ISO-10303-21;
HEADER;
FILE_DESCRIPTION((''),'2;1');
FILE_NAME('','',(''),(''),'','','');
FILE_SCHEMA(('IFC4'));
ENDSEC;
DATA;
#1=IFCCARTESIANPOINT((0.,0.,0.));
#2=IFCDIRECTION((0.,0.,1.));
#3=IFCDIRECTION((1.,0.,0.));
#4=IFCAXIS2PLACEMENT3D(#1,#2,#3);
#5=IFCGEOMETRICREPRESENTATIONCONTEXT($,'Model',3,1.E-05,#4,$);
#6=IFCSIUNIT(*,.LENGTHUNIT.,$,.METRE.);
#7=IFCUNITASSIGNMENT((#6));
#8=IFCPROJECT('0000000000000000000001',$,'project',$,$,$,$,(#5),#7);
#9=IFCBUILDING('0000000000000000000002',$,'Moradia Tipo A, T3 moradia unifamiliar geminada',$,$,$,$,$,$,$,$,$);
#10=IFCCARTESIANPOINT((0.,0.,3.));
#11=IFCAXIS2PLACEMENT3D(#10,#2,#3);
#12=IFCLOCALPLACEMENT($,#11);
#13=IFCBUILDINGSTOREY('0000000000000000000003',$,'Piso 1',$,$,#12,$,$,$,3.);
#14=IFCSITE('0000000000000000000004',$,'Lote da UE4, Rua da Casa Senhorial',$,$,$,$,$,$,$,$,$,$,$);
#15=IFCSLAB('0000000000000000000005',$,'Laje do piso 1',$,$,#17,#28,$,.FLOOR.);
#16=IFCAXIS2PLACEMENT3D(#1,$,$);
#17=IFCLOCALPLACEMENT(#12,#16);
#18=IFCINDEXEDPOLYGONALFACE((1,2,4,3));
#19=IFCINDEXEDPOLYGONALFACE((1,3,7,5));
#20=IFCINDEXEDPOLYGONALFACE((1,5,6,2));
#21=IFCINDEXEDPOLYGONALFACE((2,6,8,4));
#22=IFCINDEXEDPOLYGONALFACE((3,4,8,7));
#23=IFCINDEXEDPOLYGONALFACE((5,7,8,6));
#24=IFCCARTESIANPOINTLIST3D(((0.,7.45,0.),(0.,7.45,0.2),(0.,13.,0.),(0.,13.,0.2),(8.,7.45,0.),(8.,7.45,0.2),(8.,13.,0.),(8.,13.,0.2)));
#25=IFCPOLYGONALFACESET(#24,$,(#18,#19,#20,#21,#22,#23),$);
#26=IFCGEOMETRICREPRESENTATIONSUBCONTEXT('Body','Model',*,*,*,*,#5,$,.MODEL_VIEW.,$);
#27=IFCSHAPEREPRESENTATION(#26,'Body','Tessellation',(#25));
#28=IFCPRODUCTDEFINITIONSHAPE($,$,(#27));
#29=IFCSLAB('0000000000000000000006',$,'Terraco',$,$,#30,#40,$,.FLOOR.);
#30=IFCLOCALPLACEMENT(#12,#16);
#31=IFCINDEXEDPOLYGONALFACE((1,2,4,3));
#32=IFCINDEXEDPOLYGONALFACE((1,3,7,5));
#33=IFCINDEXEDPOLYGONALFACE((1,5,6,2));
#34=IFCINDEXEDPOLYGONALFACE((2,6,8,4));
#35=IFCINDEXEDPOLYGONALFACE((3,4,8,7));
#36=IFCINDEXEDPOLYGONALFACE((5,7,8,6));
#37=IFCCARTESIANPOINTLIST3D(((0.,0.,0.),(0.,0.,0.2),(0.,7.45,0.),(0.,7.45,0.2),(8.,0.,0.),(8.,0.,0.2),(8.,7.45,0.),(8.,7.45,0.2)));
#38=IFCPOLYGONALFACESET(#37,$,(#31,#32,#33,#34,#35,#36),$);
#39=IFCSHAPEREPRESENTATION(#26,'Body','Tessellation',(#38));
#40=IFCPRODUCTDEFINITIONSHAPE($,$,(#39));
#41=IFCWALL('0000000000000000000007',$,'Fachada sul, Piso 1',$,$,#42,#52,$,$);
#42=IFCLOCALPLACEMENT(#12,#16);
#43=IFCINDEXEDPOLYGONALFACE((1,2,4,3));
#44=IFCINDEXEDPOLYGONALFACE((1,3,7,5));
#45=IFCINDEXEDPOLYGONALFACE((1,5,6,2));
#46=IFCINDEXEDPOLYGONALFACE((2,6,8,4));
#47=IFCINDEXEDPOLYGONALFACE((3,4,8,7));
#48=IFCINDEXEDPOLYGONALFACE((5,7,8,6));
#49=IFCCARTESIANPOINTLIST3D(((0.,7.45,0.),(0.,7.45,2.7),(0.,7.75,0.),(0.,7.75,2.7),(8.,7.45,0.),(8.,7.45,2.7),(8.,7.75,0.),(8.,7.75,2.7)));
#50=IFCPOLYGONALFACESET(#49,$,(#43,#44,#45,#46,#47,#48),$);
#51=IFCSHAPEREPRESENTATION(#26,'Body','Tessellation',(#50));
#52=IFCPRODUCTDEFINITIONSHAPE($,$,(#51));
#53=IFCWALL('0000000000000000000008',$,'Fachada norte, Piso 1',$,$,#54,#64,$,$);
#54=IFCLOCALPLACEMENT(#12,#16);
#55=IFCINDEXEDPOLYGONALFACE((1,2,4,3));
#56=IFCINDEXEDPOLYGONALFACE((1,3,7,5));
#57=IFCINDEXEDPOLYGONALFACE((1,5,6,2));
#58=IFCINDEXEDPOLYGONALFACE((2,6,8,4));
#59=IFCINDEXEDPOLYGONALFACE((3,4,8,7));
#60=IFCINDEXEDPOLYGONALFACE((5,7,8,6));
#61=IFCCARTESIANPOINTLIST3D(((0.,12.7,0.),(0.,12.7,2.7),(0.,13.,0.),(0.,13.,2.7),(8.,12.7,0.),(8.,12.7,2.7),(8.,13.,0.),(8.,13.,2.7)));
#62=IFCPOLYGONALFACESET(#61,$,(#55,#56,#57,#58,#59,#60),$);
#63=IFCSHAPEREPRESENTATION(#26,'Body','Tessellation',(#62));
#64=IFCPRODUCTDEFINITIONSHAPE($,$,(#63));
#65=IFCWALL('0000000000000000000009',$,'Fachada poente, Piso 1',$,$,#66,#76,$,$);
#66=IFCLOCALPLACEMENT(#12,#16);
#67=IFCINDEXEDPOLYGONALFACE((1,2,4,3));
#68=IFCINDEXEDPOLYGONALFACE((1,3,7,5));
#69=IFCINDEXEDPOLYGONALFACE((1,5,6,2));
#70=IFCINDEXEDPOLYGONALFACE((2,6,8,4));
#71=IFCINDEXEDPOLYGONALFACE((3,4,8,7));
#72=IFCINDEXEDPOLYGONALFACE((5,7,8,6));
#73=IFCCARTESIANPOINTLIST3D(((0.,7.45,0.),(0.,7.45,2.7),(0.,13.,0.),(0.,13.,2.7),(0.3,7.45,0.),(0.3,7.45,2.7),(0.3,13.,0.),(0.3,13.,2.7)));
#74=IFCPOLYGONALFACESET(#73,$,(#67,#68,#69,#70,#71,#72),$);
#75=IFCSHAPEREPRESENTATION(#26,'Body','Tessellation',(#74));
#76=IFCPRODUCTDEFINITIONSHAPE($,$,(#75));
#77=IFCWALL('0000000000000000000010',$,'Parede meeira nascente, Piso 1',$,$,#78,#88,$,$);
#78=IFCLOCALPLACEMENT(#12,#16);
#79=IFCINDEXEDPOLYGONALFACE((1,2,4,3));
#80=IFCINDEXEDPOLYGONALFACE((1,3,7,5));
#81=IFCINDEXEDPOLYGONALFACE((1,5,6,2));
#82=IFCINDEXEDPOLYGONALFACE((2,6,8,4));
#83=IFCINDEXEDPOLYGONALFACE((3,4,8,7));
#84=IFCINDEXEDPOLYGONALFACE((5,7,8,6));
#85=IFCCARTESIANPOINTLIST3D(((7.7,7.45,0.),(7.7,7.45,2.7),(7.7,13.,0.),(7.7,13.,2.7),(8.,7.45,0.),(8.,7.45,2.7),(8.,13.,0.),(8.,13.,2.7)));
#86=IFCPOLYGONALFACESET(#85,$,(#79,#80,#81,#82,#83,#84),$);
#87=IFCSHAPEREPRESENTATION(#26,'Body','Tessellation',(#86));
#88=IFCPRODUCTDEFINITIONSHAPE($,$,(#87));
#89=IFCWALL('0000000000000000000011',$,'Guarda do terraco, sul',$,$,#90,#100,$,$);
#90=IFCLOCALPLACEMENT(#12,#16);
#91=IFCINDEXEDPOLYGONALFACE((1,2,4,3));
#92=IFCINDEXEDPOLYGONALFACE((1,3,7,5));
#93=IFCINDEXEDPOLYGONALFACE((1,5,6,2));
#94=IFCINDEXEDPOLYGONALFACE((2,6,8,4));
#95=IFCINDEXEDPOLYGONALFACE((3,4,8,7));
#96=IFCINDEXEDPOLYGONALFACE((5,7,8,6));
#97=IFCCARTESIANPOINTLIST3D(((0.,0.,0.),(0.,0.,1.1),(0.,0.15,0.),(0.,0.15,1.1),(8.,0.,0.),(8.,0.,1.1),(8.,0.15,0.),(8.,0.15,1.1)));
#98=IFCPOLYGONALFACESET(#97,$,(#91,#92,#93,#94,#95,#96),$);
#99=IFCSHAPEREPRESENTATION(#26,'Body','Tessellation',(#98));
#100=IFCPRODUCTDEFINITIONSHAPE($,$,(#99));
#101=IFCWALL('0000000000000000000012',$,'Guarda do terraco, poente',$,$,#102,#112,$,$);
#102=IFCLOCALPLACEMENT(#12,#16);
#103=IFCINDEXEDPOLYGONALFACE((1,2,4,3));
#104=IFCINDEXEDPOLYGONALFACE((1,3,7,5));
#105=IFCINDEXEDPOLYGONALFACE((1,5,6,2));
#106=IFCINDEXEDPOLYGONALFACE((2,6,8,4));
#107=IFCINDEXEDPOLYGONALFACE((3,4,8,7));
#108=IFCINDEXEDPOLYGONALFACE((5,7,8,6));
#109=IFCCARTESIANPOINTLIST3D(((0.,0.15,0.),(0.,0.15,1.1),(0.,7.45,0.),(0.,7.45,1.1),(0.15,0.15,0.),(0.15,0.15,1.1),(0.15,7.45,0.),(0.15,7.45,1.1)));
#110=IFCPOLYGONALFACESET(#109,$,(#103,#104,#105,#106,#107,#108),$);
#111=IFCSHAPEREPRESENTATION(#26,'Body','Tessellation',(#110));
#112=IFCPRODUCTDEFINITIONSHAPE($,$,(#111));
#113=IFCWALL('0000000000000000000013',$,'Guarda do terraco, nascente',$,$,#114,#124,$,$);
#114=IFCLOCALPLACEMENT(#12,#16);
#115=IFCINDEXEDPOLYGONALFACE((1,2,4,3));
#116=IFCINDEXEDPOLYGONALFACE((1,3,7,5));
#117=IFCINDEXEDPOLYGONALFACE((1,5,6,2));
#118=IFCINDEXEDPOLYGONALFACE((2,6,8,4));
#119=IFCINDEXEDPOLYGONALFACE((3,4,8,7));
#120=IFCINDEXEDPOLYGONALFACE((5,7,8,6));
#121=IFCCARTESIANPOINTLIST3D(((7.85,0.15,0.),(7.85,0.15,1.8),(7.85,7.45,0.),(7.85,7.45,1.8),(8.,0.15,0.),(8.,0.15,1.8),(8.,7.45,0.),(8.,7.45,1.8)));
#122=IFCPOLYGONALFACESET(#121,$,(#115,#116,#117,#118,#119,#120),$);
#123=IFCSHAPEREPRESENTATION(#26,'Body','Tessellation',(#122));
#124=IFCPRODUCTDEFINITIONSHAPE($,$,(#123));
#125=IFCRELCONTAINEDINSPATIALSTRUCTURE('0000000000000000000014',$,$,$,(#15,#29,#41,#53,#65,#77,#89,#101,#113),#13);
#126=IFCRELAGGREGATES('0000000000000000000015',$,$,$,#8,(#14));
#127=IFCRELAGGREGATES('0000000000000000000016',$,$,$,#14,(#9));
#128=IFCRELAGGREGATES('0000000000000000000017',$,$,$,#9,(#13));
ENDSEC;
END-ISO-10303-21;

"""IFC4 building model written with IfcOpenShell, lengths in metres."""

from ifc_helpers import new_model, si_unit, frame, origin_with_axes, place, context, subcontext, project, spatial, indexed_curve, outline, extrude, element, save


model = new_model("IFC4")

# Units and contexts
model_context = context("Model", 3, precision=1e-05, world=origin_with_axes())
body_context = subcontext(model_context, "Body", "Model", "MODEL_VIEW")
ifc_project = project(units=[si_unit("LENGTHUNIT", "METRE")], contexts=[model_context])

# Site, building, storey
site = spatial("IfcSite", under=ifc_project, Name="Lote da UE4, Rua da Casa Senhorial")
building = spatial("IfcBuilding", under=site, Name="Moradia Tipo A, T3 moradia unifamiliar geminada")
storey_placement = place(None, frame((0.0, 0.0, 3.0), z_axis=(0.0, 0.0, 1.0), x_axis=(1.0, 0.0, 0.0)))
storey = spatial("IfcBuildingStorey", under=building, at=storey_placement, Name="Piso 1", Elevation=3.0)

# Slabs
slab_1_placement = place(storey_placement, frame((0.0, 7.45, 0.0), z_axis=(0.0, 0.0, 1.0), x_axis=(1.0, 0.0, 0.0)))
element("IfcSlab", 1, at=slab_1_placement, inside=storey, Name="Laje do piso 1", PredefinedType="FLOOR", context=body_context, shape_type="SweptSolid", body=[
    extrude(outline(indexed_curve([(0.0, 0.0), (8.0, 0.0), (8.0, 5.55), (0.0, 5.55), (0.0, 0.0)])), None, (0.0, 0.0, 1.0), 0.2),
])
slab_2_placement = place(storey_placement, origin_with_axes())
element("IfcSlab", 2, at=slab_2_placement, inside=storey, Name="Terraco", PredefinedType="FLOOR", context=body_context, shape_type="SweptSolid", body=[
    extrude(outline(indexed_curve([(0.0, 0.0), (8.0, 0.0), (8.0, 7.45), (0.0, 7.45), (0.0, 0.0)])), None, (0.0, 0.0, 1.0), 0.2),
])

# Walls
for number, where, z_axis, x_axis, name in (
    (3, (0.0, 7.45, 0.0), (0.0, 0.0, 1.0), (1.0, 0.0, 0.0), "Fachada sul, Piso 1"),
    (4, (0.0, 12.7, 0.0), (0.0, 0.0, 1.0), (1.0, 0.0, 0.0), "Fachada norte, Piso 1"),
):
    element("IfcWall", number, at=place(storey_placement, frame(where, z_axis=z_axis, x_axis=x_axis)), inside=storey, Name=name, context=body_context, shape_type="SweptSolid", body=[
        extrude(outline(indexed_curve([(0.0, 0.0), (0.0, 0.3), (8.0, 0.3), (8.0, 0.0), (0.0, 0.0)], self_intersect=False)), origin_with_axes(), (0.0, 0.0, 1.0), 2.7),
    ])
for number, where, z_axis, x_axis, name in (
    (5, (0.3, 7.45, 0.0), (0.0, 0.0, 1.0), (0.0, 1.0, 0.0), "Fachada poente, Piso 1"),
    (6, (8.0, 7.45, 0.0), (0.0, 0.0, 1.0), (0.0, 1.0, 0.0), "Parede meeira nascente, Piso 1"),
):
    element("IfcWall", number, at=place(storey_placement, frame(where, z_axis=z_axis, x_axis=x_axis)), inside=storey, Name=name, context=body_context, shape_type="SweptSolid", body=[
        extrude(outline(indexed_curve([(0.0, 0.0), (0.0, 0.3), (5.55, 0.3), (5.55, 0.0), (0.0, 0.0)], self_intersect=False)), origin_with_axes(), (0.0, 0.0, 1.0), 2.7),
    ])
wall_1_placement = place(storey_placement, origin_with_axes())
element("IfcWall", 7, at=wall_1_placement, inside=storey, Name="Guarda do terraco, sul", context=body_context, shape_type="SweptSolid", body=[
    extrude(outline(indexed_curve([(0.0, 0.0), (0.0, 0.15), (8.0, 0.15), (8.0, 0.0), (0.0, 0.0)], self_intersect=False)), origin_with_axes(), (0.0, 0.0, 1.0), 1.1),
])
wall_2_placement = place(storey_placement, frame((0.15, 0.15, 0.0), z_axis=(0.0, 0.0, 1.0), x_axis=(0.0, 1.0, 0.0)))
element("IfcWall", 8, at=wall_2_placement, inside=storey, Name="Guarda do terraco, poente", context=body_context, shape_type="SweptSolid", body=[
    extrude(outline(indexed_curve([(0.0, 0.0), (0.0, 0.15), (7.3, 0.15), (7.3, 0.0), (0.0, 0.0)], self_intersect=False)), origin_with_axes(), (0.0, 0.0, 1.0), 1.1),
])
wall_3_placement = place(storey_placement, frame((8.0, 0.15, 0.0), z_axis=(0.0, 0.0, 1.0), x_axis=(0.0, 1.0, 0.0)))
element("IfcWall", 9, at=wall_3_placement, inside=storey, Name="Guarda do terraco, nascente", context=body_context, shape_type="SweptSolid", body=[
    extrude(outline(indexed_curve([(0.0, 0.0), (0.0, 0.15), (7.3, 0.15), (7.3, 0.0), (0.0, 0.0)], self_intersect=False)), origin_with_axes(), (0.0, 0.0, 1.0), 1.8),
])

save(model, "model.ifc")
